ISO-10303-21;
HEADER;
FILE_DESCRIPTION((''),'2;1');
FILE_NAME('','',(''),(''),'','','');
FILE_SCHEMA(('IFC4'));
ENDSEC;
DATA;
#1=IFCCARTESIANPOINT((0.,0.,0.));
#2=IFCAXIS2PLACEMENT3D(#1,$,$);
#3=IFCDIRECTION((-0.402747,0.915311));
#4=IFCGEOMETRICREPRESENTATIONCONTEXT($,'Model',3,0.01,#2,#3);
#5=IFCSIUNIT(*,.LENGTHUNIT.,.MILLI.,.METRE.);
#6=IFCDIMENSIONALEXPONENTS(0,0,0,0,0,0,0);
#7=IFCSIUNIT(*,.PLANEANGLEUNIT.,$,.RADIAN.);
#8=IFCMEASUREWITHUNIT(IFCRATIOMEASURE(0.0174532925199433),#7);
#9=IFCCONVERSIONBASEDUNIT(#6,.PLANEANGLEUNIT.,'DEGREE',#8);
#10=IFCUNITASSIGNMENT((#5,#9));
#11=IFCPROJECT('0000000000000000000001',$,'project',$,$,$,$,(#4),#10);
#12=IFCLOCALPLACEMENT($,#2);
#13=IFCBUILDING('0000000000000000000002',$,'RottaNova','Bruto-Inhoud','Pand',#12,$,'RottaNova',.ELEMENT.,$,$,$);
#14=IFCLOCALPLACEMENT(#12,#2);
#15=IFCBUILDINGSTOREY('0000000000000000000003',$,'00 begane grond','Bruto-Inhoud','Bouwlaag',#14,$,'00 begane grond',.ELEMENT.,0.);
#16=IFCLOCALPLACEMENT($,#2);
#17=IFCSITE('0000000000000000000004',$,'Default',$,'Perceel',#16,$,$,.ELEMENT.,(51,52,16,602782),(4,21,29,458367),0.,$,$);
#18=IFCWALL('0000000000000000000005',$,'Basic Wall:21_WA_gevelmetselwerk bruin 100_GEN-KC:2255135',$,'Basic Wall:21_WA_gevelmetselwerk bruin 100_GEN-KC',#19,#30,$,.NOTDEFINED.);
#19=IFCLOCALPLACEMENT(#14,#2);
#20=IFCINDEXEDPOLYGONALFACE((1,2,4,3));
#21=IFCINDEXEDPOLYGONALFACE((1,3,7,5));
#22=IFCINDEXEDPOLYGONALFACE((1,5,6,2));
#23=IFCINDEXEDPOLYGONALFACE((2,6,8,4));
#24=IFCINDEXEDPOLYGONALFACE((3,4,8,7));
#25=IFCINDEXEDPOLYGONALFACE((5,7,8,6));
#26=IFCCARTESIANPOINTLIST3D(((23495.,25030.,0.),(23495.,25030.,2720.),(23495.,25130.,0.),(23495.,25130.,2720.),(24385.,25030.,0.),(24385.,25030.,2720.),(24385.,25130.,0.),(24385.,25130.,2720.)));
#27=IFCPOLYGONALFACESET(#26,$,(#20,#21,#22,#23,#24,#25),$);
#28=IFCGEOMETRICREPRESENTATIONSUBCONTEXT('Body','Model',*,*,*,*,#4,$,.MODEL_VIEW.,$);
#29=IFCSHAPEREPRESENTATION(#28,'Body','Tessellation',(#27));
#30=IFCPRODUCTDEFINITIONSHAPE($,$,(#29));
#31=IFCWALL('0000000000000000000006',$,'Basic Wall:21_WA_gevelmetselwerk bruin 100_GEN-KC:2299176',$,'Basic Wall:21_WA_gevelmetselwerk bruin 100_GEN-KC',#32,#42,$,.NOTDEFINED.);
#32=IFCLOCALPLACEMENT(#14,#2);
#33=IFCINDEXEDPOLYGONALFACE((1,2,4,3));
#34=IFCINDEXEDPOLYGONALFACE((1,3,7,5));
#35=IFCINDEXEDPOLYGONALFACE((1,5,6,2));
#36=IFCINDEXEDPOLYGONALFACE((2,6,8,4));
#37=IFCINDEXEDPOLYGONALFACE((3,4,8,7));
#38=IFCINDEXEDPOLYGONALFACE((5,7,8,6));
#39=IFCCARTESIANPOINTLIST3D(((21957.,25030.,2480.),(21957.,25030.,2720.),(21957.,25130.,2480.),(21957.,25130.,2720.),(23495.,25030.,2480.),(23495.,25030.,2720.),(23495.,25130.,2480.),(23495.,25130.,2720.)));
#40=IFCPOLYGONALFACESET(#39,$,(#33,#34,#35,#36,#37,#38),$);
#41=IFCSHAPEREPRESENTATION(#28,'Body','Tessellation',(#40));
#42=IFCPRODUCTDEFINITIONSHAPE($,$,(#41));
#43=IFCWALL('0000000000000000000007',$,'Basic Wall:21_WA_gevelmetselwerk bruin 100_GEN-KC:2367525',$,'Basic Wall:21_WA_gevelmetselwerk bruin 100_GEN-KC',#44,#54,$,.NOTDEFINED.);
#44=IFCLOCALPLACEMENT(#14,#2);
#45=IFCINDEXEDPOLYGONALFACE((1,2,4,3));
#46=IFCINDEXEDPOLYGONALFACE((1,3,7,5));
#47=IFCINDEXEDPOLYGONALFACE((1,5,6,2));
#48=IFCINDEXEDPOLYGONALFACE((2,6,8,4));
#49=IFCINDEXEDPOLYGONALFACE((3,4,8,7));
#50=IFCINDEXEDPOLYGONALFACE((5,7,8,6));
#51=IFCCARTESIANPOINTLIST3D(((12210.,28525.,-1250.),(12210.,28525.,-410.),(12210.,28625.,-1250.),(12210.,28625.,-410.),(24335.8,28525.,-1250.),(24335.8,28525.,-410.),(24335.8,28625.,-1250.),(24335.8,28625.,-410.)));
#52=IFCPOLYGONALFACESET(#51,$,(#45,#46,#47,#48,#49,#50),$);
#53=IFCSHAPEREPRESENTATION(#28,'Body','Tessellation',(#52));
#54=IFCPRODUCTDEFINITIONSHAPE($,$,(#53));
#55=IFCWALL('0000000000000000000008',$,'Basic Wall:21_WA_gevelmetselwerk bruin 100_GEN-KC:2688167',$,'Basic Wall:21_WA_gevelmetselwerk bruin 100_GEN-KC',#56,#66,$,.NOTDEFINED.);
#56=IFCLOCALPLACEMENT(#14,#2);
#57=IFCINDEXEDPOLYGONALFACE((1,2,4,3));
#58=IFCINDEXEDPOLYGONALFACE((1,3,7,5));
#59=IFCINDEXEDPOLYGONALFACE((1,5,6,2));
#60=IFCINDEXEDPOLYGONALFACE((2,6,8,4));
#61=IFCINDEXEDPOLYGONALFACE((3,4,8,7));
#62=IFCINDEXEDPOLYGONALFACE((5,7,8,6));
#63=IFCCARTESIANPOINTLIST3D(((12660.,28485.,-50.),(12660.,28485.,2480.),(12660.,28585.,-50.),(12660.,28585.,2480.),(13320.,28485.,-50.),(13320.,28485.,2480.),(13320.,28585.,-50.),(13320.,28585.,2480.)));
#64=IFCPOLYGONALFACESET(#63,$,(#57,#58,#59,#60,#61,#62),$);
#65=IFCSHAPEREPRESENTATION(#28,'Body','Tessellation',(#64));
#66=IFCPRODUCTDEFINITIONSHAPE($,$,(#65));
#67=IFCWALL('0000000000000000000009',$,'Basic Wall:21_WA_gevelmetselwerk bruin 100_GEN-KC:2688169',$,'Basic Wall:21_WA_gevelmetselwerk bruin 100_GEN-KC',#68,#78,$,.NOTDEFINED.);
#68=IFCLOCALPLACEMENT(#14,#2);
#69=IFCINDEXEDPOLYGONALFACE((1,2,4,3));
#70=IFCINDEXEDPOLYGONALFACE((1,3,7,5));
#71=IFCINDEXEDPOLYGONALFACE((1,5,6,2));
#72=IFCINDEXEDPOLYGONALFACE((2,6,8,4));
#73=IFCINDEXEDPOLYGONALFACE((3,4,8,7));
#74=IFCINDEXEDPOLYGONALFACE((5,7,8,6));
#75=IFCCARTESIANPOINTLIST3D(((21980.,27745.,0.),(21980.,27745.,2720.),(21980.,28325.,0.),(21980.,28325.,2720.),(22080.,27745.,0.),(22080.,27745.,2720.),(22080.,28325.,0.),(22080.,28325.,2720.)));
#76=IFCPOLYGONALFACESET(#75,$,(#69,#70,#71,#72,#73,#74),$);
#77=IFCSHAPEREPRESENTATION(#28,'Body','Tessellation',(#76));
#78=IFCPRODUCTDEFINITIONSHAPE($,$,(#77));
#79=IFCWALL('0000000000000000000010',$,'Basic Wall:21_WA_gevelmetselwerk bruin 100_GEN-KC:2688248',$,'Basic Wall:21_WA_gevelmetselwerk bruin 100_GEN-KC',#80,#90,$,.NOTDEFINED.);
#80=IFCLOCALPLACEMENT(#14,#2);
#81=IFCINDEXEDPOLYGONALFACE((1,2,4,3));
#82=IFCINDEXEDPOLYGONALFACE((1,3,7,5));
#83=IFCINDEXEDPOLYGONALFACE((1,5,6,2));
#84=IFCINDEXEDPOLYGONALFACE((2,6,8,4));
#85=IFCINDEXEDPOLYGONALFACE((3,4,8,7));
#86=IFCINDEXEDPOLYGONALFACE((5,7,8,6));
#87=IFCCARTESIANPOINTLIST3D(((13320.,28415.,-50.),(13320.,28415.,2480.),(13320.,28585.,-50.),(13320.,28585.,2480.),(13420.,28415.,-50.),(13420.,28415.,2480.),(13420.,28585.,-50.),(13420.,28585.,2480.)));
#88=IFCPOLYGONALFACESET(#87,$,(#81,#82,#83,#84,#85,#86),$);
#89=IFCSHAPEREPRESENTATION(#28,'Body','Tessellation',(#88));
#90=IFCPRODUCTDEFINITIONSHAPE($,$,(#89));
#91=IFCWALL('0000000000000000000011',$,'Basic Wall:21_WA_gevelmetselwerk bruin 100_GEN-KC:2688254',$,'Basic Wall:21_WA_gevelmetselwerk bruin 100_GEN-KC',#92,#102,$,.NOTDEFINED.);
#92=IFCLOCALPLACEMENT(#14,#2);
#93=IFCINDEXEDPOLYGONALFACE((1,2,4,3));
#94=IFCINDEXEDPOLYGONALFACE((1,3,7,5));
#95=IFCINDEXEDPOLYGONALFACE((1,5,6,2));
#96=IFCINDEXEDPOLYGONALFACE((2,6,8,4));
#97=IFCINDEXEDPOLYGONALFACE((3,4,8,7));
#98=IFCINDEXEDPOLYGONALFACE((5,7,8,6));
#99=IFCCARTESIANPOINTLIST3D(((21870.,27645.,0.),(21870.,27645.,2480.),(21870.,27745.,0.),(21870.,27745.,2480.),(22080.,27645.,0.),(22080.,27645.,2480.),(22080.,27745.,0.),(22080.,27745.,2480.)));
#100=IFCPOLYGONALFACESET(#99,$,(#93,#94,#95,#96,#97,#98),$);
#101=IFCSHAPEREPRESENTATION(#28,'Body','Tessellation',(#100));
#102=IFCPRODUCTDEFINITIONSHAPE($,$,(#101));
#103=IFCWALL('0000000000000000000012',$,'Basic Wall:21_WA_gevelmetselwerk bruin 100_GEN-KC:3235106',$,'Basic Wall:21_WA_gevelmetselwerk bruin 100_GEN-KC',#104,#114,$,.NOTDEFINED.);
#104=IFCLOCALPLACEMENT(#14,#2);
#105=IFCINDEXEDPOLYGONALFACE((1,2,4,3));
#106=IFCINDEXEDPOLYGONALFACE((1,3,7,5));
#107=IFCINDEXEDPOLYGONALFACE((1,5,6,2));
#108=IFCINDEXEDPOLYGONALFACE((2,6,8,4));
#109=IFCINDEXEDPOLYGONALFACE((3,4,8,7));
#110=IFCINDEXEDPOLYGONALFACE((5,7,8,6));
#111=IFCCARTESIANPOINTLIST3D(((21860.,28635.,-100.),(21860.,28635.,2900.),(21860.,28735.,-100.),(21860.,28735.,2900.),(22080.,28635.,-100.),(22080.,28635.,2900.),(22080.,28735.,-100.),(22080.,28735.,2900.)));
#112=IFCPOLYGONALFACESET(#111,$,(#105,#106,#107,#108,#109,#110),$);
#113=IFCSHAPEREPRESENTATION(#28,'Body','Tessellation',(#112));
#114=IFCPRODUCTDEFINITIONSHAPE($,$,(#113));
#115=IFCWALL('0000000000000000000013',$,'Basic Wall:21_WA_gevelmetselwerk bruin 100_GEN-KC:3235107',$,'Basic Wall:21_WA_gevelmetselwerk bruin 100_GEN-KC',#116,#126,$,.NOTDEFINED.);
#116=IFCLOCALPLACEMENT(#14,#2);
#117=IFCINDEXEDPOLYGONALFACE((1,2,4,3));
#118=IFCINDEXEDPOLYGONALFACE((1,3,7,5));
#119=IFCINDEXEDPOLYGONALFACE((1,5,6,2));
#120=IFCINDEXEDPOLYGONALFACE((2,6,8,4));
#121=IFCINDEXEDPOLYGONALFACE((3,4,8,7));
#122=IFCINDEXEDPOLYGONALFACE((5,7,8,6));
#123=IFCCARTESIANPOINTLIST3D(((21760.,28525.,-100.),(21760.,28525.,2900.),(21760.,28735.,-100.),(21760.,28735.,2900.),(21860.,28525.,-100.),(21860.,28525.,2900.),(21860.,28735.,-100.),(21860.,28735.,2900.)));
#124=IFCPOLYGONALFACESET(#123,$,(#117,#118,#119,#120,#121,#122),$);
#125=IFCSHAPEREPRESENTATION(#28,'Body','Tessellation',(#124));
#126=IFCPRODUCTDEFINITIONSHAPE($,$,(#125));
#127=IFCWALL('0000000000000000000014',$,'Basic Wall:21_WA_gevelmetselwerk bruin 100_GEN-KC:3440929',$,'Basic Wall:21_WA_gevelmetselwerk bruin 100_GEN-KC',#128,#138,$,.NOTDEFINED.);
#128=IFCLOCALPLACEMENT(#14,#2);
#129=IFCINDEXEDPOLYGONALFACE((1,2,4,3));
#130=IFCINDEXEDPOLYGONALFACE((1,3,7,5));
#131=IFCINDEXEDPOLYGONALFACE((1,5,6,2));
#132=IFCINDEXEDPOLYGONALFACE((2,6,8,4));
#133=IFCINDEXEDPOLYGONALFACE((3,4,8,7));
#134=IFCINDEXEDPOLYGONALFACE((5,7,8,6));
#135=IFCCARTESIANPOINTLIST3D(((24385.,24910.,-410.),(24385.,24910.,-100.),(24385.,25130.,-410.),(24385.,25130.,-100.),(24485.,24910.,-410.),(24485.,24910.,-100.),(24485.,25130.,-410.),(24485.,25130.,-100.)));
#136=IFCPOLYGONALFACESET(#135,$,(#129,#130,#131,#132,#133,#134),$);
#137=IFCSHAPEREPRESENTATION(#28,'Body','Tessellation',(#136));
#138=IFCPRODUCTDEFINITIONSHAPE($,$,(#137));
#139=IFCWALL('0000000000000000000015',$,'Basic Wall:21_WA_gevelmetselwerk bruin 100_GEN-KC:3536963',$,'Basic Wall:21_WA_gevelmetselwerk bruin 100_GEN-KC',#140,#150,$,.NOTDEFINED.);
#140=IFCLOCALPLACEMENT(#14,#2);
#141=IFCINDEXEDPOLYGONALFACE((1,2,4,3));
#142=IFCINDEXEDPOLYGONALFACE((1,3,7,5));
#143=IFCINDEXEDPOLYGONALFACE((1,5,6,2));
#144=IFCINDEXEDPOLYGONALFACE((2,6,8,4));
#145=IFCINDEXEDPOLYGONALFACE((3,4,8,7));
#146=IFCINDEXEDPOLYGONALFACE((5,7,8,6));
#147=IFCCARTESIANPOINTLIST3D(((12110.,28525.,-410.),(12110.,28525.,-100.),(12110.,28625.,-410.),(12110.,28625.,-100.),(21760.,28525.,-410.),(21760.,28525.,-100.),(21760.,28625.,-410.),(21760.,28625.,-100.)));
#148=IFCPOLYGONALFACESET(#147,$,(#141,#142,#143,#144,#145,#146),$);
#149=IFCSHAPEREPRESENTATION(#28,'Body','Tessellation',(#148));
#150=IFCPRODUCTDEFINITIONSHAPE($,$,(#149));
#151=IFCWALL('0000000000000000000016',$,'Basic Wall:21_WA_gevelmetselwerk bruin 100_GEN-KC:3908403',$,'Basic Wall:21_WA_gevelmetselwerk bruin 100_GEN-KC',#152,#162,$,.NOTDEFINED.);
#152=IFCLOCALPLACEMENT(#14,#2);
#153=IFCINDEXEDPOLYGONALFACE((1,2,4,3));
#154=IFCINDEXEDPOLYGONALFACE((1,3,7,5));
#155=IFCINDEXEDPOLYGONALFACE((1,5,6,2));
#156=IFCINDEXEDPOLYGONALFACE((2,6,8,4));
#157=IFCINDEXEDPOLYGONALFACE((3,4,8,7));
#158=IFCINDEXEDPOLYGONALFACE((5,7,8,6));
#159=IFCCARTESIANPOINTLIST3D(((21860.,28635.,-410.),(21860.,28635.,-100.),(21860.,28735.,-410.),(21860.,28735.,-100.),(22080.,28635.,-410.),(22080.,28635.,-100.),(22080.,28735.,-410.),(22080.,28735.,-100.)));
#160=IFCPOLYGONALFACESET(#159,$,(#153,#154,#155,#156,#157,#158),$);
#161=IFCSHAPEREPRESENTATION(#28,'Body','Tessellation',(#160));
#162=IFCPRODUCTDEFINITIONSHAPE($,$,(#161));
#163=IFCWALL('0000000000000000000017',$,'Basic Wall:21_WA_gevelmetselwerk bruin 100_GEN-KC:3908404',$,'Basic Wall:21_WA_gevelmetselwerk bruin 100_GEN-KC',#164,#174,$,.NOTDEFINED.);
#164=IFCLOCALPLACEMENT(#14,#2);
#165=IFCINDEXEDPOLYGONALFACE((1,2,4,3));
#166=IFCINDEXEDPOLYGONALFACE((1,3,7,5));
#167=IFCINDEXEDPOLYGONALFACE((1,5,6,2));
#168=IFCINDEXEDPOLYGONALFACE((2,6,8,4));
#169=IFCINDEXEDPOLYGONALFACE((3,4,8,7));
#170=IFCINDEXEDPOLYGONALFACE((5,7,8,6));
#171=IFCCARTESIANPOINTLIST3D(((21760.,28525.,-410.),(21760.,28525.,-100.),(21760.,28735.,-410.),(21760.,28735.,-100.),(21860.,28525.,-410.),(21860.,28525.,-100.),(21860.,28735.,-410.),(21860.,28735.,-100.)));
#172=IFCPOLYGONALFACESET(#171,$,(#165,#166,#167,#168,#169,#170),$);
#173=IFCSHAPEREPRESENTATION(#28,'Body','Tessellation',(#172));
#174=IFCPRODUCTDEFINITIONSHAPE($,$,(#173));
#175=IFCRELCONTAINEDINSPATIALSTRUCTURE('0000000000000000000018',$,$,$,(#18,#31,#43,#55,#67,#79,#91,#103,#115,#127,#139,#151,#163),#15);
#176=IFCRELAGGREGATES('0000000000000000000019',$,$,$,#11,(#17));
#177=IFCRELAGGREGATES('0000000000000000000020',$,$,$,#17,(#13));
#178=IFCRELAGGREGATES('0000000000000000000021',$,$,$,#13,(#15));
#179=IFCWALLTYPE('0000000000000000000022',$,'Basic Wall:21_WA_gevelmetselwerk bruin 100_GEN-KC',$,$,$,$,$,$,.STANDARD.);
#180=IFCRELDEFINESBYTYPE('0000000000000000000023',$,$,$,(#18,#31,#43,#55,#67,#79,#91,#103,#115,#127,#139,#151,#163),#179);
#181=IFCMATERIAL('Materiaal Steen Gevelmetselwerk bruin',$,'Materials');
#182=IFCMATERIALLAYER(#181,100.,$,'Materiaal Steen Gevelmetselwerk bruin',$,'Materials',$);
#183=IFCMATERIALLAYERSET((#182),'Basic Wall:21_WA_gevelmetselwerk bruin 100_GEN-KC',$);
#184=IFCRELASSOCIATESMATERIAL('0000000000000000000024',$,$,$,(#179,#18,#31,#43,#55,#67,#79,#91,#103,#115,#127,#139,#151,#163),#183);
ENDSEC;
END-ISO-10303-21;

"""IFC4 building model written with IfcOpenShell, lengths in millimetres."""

from ifc_helpers import new_model, entity, si_unit, converted_unit, direction, frame, frame_2d, origin, place, context, subcontext, project, spatial, rectangle, extrude, material, layer, layer_set, type_object, element, save


model = new_model("IFC4")

# Units and contexts
model_context = context("Model", 3, precision=0.01, world=origin(), true_north=direction((-0.402747, 0.915311)))
body_context = subcontext(model_context, "Body", "Model", "MODEL_VIEW")
ifc_project = project(units=[si_unit("LENGTHUNIT", "METRE", prefix="MILLI"), converted_unit("PLANEANGLEUNIT", "DEGREE", entity("IfcRatioMeasure", 0.0174532925199433), si_unit("PLANEANGLEUNIT", "RADIAN"), dimensions=[0, 0, 0, 0, 0, 0, 0])], contexts=[model_context])

# Site, building, storey
site_placement = place(None, origin())
site = spatial("IfcSite", under=ifc_project, at=site_placement, Name="Default", ObjectType="Perceel", CompositionType="ELEMENT", RefLatitude=(51, 52, 16, 602782), RefLongitude=(4, 21, 29, 458367), RefElevation=0.0)
building_placement = place(None, origin())
building = spatial("IfcBuilding", under=site, at=building_placement, Name="RottaNova", Description="Bruto-Inhoud", ObjectType="Pand", LongName="RottaNova", CompositionType="ELEMENT")
storey_placement = place(building_placement, origin())
storey = spatial("IfcBuildingStorey", under=building, at=storey_placement, Name="00 begane grond", Description="Bruto-Inhoud", ObjectType="Bouwlaag", LongName="00 begane grond", CompositionType="ELEMENT", Elevation=0.0)

# Walls
ifc_material_1 = material(Name="Materiaal Steen Gevelmetselwerk bruin", Category="Materials")
ifc_layer_1 = layer(ifc_material_1, 100.0, Name="Materiaal Steen Gevelmetselwerk bruin", Category="Materials")
ifc_layer_set_1 = layer_set([ifc_layer_1], Name="Basic Wall:21_WA_gevelmetselwerk bruin 100_GEN-KC")
wall_type_1 = type_object("IfcWallType", Name="Basic Wall:21_WA_gevelmetselwerk bruin 100_GEN-KC", PredefinedType="STANDARD", material=ifc_layer_set_1)
wall_1_placement = place(storey_placement, frame((24385.0, 25080.0, 0.0), z_axis=(0.0, 0.0, 1.0), x_axis=(-1.0, 0.0, 0.0)))
element("IfcWall", 1, at=wall_1_placement, inside=storey, type_object=wall_type_1, material=ifc_layer_set_1, Name="Basic Wall:21_WA_gevelmetselwerk bruin 100_GEN-KC:2255135", ObjectType="Basic Wall:21_WA_gevelmetselwerk bruin 100_GEN-KC", PredefinedType="NOTDEFINED", context=body_context, shape_type="SweptSolid", body=[
    extrude(rectangle(XDim=890.0, YDim=100.0, at=frame_2d((445.0, 0.0), x_axis=(-1.0, 0.0))), origin(), (0.0, 0.0, 1.0), 2720.0),
])
wall_2_placement = place(storey_placement, frame((23495.0, 25080.0, 2480.0), z_axis=(0.0, 0.0, 1.0), x_axis=(-1.0, 0.0, 0.0)))
element("IfcWall", 2, at=wall_2_placement, inside=storey, type_object=wall_type_1, material=ifc_layer_set_1, Name="Basic Wall:21_WA_gevelmetselwerk bruin 100_GEN-KC:2299176", ObjectType="Basic Wall:21_WA_gevelmetselwerk bruin 100_GEN-KC", PredefinedType="NOTDEFINED", context=body_context, shape_type="SweptSolid", body=[
    extrude(rectangle(XDim=1538.0, YDim=100.0, at=frame_2d((769.0, 0.0), x_axis=(-1.0, 0.0))), origin(), (0.0, 0.0, 1.0), 240.0),
])
wall_3_placement = place(storey_placement, frame((24335.8, 28575.0, -1250.0), z_axis=(0.0, 0.0, 1.0), x_axis=(-1.0, 0.0, 0.0)))
element("IfcWall", 3, at=wall_3_placement, inside=storey, type_object=wall_type_1, material=ifc_layer_set_1, Name="Basic Wall:21_WA_gevelmetselwerk bruin 100_GEN-KC:2367525", ObjectType="Basic Wall:21_WA_gevelmetselwerk bruin 100_GEN-KC", PredefinedType="NOTDEFINED", context=body_context, shape_type="SweptSolid", body=[
    extrude(rectangle(XDim=12125.8, YDim=100.0, at=frame_2d((6062.9, 0.0), x_axis=(-1.0, 0.0))), origin(), (0.0, 0.0, 1.0), 840.0),
])
wall_4_placement = place(storey_placement, frame((12660.0, 28535.0, -50.0)))
element("IfcWall", 4, at=wall_4_placement, inside=storey, type_object=wall_type_1, material=ifc_layer_set_1, Name="Basic Wall:21_WA_gevelmetselwerk bruin 100_GEN-KC:2688167", ObjectType="Basic Wall:21_WA_gevelmetselwerk bruin 100_GEN-KC", PredefinedType="NOTDEFINED", context=body_context, shape_type="SweptSolid", body=[
    extrude(rectangle(XDim=660.0, YDim=100.0, at=frame_2d((330.0, 0.0), x_axis=(-1.0, 0.0))), origin(), (0.0, 0.0, 1.0), 2530.0),
])
wall_5_placement = place(storey_placement, frame((22030.0, 27745.0, 0.0), z_axis=(0.0, 0.0, 1.0), x_axis=(0.0, 1.0, 0.0)))
element("IfcWall", 5, at=wall_5_placement, inside=storey, type_object=wall_type_1, material=ifc_layer_set_1, Name="Basic Wall:21_WA_gevelmetselwerk bruin 100_GEN-KC:2688169", ObjectType="Basic Wall:21_WA_gevelmetselwerk bruin 100_GEN-KC", PredefinedType="NOTDEFINED", context=body_context, shape_type="SweptSolid", body=[
    extrude(rectangle(XDim=580.0, YDim=100.0, at=frame_2d((290.0, 0.0), x_axis=(-1.0, 0.0))), origin(), (0.0, 0.0, 1.0), 2720.0),
])
wall_6_placement = place(storey_placement, frame((13370.0, 28415.0, -50.0), z_axis=(0.0, 0.0, 1.0), x_axis=(0.0, 1.0, 0.0)))
element("IfcWall", 6, at=wall_6_placement, inside=storey, type_object=wall_type_1, material=ifc_layer_set_1, Name="Basic Wall:21_WA_gevelmetselwerk bruin 100_GEN-KC:2688248", ObjectType="Basic Wall:21_WA_gevelmetselwerk bruin 100_GEN-KC", PredefinedType="NOTDEFINED", context=body_context, shape_type="SweptSolid", body=[
    extrude(rectangle(XDim=170.0, YDim=100.0, at=frame_2d((85.0, 0.0), x_axis=(-1.0, 0.0))), origin(), (0.0, 0.0, 1.0), 2530.0),
])
wall_7_placement = place(storey_placement, frame((21870.0, 27695.0, 0.0)))
element("IfcWall", 7, at=wall_7_placement, inside=storey, type_object=wall_type_1, material=ifc_layer_set_1, Name="Basic Wall:21_WA_gevelmetselwerk bruin 100_GEN-KC:2688254", ObjectType="Basic Wall:21_WA_gevelmetselwerk bruin 100_GEN-KC", PredefinedType="NOTDEFINED", context=body_context, shape_type="SweptSolid", body=[
    extrude(rectangle(XDim=210.0, YDim=100.0, at=frame_2d((105.0, 0.0), x_axis=(-1.0, 0.0))), origin(), (0.0, 0.0, 1.0), 2480.0),
])
wall_8_placement = place(storey_placement, frame((22080.0, 28685.0, -100.0), z_axis=(0.0, 0.0, 1.0), x_axis=(-1.0, 0.0, 0.0)))
element("IfcWall", 8, at=wall_8_placement, inside=storey, type_object=wall_type_1, material=ifc_layer_set_1, Name="Basic Wall:21_WA_gevelmetselwerk bruin 100_GEN-KC:3235106", ObjectType="Basic Wall:21_WA_gevelmetselwerk bruin 100_GEN-KC", PredefinedType="NOTDEFINED", context=body_context, shape_type="SweptSolid", body=[
    extrude(rectangle(XDim=220.0, YDim=100.0, at=frame_2d((110.0, 0.0), x_axis=(-1.0, 0.0))), origin(), (0.0, 0.0, 1.0), 3000.0),
])
wall_9_placement = place(storey_placement, frame((21810.0, 28735.0, -100.0), z_axis=(0.0, 0.0, 1.0), x_axis=(0.0, -1.0, 0.0)))
element("IfcWall", 9, at=wall_9_placement, inside=storey, type_object=wall_type_1, material=ifc_layer_set_1, Name="Basic Wall:21_WA_gevelmetselwerk bruin 100_GEN-KC:3235107", ObjectType="Basic Wall:21_WA_gevelmetselwerk bruin 100_GEN-KC", PredefinedType="NOTDEFINED", context=body_context, shape_type="SweptSolid", body=[
    extrude(rectangle(XDim=210.0, YDim=100.0, at=frame_2d((105.0, 0.0), x_axis=(-1.0, 0.0))), origin(), (0.0, 0.0, 1.0), 3000.0),
])
wall_10_placement = place(storey_placement, frame((24435.0, 25130.0, -410.0), z_axis=(0.0, 0.0, 1.0), x_axis=(0.0, -1.0, 0.0)))
element("IfcWall", 10, at=wall_10_placement, inside=storey, type_object=wall_type_1, material=ifc_layer_set_1, Name="Basic Wall:21_WA_gevelmetselwerk bruin 100_GEN-KC:3440929", ObjectType="Basic Wall:21_WA_gevelmetselwerk bruin 100_GEN-KC", PredefinedType="NOTDEFINED", context=body_context, shape_type="SweptSolid", body=[
    extrude(rectangle(XDim=220.0, YDim=100.0, at=frame_2d((110.0, 0.0), x_axis=(-1.0, 0.0))), origin(), (0.0, 0.0, 1.0), 310.0),
])
wall_11_placement = place(storey_placement, frame((21760.0, 28575.0, -410.0), z_axis=(0.0, 0.0, 1.0), x_axis=(-1.0, 0.0, 0.0)))
element("IfcWall", 11, at=wall_11_placement, inside=storey, type_object=wall_type_1, material=ifc_layer_set_1, Name="Basic Wall:21_WA_gevelmetselwerk bruin 100_GEN-KC:3536963", ObjectType="Basic Wall:21_WA_gevelmetselwerk bruin 100_GEN-KC", PredefinedType="NOTDEFINED", context=body_context, shape_type="SweptSolid", body=[
    extrude(rectangle(XDim=9650.0, YDim=100.0, at=frame_2d((4825.0, 0.0), x_axis=(-1.0, 0.0))), origin(), (0.0, 0.0, 1.0), 310.0),
])
wall_12_placement = place(storey_placement, frame((22080.0, 28685.0, -410.0), z_axis=(0.0, 0.0, 1.0), x_axis=(-1.0, 0.0, 0.0)))
element("IfcWall", 12, at=wall_12_placement, inside=storey, type_object=wall_type_1, material=ifc_layer_set_1, Name="Basic Wall:21_WA_gevelmetselwerk bruin 100_GEN-KC:3908403", ObjectType="Basic Wall:21_WA_gevelmetselwerk bruin 100_GEN-KC", PredefinedType="NOTDEFINED", context=body_context, shape_type="SweptSolid", body=[
    extrude(rectangle(XDim=220.0, YDim=100.0, at=frame_2d((110.0, 0.0), x_axis=(-1.0, 0.0))), origin(), (0.0, 0.0, 1.0), 310.0),
])
wall_13_placement = place(storey_placement, frame((21810.0, 28735.0, -410.0), z_axis=(0.0, 0.0, 1.0), x_axis=(0.0, -1.0, 0.0)))
element("IfcWall", 13, at=wall_13_placement, inside=storey, type_object=wall_type_1, material=ifc_layer_set_1, Name="Basic Wall:21_WA_gevelmetselwerk bruin 100_GEN-KC:3908404", ObjectType="Basic Wall:21_WA_gevelmetselwerk bruin 100_GEN-KC", PredefinedType="NOTDEFINED", context=body_context, shape_type="SweptSolid", body=[
    extrude(rectangle(XDim=210.0, YDim=100.0, at=frame_2d((105.0, 0.0), x_axis=(-1.0, 0.0))), origin(), (0.0, 0.0, 1.0), 310.0),
])

save(model, "model.ifc")
